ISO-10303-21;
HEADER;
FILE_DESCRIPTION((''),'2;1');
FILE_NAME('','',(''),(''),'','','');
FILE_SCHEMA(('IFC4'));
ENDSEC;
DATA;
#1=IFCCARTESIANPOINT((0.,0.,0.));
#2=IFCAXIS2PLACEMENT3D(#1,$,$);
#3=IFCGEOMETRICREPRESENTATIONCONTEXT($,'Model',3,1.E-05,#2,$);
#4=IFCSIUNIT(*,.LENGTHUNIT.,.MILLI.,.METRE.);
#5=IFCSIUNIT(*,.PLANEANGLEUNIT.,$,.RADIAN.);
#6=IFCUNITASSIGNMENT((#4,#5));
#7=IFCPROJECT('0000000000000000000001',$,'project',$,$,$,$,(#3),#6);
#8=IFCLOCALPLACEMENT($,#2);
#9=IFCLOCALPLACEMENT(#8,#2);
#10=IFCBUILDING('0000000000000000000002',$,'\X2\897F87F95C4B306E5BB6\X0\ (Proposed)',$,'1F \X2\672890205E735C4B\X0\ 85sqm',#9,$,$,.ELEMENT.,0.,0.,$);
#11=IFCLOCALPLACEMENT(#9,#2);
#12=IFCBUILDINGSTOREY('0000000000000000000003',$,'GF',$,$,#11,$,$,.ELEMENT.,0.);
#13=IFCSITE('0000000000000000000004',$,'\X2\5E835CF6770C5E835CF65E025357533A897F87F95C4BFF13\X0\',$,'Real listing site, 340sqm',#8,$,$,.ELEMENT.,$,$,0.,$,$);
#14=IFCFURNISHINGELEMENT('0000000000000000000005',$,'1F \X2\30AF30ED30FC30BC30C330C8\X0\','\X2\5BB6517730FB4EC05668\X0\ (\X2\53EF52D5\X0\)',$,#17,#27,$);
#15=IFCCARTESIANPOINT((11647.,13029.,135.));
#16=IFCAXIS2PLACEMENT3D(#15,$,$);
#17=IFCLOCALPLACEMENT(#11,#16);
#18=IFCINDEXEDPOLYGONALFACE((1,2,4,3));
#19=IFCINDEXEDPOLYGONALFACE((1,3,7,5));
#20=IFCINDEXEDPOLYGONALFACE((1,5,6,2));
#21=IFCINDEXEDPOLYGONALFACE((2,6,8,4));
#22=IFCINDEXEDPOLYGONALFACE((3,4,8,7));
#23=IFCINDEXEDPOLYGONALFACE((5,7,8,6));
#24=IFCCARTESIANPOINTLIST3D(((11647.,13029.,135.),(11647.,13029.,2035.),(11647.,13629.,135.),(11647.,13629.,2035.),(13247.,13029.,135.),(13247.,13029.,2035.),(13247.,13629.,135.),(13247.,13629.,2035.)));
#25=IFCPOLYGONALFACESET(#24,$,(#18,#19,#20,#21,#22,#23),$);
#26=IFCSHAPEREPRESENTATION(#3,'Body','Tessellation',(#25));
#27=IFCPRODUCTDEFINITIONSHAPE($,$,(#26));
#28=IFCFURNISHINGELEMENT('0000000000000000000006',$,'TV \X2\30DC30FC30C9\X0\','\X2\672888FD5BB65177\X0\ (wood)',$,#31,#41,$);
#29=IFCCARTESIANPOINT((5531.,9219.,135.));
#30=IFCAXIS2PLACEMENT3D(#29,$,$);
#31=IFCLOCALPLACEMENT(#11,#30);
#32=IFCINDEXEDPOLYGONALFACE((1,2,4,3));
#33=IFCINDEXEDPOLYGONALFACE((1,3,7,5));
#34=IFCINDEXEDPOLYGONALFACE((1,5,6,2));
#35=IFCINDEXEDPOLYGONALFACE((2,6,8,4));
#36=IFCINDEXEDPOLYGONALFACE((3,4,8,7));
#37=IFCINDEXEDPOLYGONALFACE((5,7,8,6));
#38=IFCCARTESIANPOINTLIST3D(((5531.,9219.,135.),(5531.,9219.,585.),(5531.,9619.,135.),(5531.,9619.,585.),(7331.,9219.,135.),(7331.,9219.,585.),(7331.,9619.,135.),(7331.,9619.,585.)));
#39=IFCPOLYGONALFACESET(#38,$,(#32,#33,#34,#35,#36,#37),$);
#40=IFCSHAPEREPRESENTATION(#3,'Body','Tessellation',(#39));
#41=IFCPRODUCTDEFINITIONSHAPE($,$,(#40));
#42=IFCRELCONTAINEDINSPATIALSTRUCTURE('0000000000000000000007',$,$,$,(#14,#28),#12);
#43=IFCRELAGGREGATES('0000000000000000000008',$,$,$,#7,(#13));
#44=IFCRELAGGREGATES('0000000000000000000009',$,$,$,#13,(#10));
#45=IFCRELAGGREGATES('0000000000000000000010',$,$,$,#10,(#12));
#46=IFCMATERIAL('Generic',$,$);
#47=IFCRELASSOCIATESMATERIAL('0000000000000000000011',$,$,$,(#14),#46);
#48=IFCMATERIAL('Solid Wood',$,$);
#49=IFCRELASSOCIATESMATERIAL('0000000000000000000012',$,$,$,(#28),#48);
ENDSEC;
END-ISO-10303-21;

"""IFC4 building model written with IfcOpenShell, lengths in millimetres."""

from ifc_helpers import new_model, si_unit, frame, frame_2d, origin, place, context, project, spatial, rectangle, extrude, material, element, save


model = new_model("IFC4")

# Units and contexts
model_context = context("Model", 3, precision=1e-05, world=origin())
ifc_project = project(units=[si_unit("LENGTHUNIT", "METRE", prefix="MILLI"), si_unit("PLANEANGLEUNIT", "RADIAN")], contexts=[model_context])

# Site, building, storey
site_placement = place(None, origin())
site = spatial("IfcSite", under=ifc_project, at=site_placement, Name="広島県広島市南区西蟹屋３", ObjectType="Real listing site, 340sqm", CompositionType="ELEMENT", RefElevation=0.0)
building_placement = place(site_placement, origin())
building = spatial("IfcBuilding", under=site, at=building_placement, Name="西蟹屋の家 (Proposed)", ObjectType="1F 木造平屋 85sqm", CompositionType="ELEMENT", ElevationOfRefHeight=0.0, ElevationOfTerrain=0.0)
storey_placement = place(building_placement, origin())
storey = spatial("IfcBuildingStorey", under=building, at=storey_placement, Name="GF", CompositionType="ELEMENT", Elevation=0.0)

# Shared definitions
ifc_material_1 = material(Name="Solid Wood")

# Shared definitions
ifc_material_2 = material(Name="Generic")

# Furnishing elements
furnishing_1_placement = place(storey_placement, frame((11647.0, 13029.0, 135.0)))
element("IfcFurnishingElement", 1, at=furnishing_1_placement, inside=storey, material=ifc_material_2, Name="1F クローゼット", Description="家具・什器 (可動)", context=model_context, shape_type="SweptSolid", body=[
    extrude(rectangle(XDim=1600.0, YDim=600.0, at=frame_2d((800.0, 300.0))), frame((11647.0, 13029.0, 135.0)), (0.0, 0.0, 1.0), 1900.0),
])
furnishing_2_placement = place(storey_placement, frame((5531.0, 9219.0, 135.0)))
element("IfcFurnishingElement", 2, at=furnishing_2_placement, inside=storey, material=ifc_material_1, Name="TV ボード", Description="木製家具 (wood)", context=model_context, shape_type="SweptSolid", body=[
    extrude(rectangle(XDim=1800.0, YDim=400.0, at=frame_2d((900.0, 200.0))), frame((5531.0, 9219.0, 135.0)), (0.0, 0.0, 1.0), 450.0),
])

save(model, "model.ifc")
